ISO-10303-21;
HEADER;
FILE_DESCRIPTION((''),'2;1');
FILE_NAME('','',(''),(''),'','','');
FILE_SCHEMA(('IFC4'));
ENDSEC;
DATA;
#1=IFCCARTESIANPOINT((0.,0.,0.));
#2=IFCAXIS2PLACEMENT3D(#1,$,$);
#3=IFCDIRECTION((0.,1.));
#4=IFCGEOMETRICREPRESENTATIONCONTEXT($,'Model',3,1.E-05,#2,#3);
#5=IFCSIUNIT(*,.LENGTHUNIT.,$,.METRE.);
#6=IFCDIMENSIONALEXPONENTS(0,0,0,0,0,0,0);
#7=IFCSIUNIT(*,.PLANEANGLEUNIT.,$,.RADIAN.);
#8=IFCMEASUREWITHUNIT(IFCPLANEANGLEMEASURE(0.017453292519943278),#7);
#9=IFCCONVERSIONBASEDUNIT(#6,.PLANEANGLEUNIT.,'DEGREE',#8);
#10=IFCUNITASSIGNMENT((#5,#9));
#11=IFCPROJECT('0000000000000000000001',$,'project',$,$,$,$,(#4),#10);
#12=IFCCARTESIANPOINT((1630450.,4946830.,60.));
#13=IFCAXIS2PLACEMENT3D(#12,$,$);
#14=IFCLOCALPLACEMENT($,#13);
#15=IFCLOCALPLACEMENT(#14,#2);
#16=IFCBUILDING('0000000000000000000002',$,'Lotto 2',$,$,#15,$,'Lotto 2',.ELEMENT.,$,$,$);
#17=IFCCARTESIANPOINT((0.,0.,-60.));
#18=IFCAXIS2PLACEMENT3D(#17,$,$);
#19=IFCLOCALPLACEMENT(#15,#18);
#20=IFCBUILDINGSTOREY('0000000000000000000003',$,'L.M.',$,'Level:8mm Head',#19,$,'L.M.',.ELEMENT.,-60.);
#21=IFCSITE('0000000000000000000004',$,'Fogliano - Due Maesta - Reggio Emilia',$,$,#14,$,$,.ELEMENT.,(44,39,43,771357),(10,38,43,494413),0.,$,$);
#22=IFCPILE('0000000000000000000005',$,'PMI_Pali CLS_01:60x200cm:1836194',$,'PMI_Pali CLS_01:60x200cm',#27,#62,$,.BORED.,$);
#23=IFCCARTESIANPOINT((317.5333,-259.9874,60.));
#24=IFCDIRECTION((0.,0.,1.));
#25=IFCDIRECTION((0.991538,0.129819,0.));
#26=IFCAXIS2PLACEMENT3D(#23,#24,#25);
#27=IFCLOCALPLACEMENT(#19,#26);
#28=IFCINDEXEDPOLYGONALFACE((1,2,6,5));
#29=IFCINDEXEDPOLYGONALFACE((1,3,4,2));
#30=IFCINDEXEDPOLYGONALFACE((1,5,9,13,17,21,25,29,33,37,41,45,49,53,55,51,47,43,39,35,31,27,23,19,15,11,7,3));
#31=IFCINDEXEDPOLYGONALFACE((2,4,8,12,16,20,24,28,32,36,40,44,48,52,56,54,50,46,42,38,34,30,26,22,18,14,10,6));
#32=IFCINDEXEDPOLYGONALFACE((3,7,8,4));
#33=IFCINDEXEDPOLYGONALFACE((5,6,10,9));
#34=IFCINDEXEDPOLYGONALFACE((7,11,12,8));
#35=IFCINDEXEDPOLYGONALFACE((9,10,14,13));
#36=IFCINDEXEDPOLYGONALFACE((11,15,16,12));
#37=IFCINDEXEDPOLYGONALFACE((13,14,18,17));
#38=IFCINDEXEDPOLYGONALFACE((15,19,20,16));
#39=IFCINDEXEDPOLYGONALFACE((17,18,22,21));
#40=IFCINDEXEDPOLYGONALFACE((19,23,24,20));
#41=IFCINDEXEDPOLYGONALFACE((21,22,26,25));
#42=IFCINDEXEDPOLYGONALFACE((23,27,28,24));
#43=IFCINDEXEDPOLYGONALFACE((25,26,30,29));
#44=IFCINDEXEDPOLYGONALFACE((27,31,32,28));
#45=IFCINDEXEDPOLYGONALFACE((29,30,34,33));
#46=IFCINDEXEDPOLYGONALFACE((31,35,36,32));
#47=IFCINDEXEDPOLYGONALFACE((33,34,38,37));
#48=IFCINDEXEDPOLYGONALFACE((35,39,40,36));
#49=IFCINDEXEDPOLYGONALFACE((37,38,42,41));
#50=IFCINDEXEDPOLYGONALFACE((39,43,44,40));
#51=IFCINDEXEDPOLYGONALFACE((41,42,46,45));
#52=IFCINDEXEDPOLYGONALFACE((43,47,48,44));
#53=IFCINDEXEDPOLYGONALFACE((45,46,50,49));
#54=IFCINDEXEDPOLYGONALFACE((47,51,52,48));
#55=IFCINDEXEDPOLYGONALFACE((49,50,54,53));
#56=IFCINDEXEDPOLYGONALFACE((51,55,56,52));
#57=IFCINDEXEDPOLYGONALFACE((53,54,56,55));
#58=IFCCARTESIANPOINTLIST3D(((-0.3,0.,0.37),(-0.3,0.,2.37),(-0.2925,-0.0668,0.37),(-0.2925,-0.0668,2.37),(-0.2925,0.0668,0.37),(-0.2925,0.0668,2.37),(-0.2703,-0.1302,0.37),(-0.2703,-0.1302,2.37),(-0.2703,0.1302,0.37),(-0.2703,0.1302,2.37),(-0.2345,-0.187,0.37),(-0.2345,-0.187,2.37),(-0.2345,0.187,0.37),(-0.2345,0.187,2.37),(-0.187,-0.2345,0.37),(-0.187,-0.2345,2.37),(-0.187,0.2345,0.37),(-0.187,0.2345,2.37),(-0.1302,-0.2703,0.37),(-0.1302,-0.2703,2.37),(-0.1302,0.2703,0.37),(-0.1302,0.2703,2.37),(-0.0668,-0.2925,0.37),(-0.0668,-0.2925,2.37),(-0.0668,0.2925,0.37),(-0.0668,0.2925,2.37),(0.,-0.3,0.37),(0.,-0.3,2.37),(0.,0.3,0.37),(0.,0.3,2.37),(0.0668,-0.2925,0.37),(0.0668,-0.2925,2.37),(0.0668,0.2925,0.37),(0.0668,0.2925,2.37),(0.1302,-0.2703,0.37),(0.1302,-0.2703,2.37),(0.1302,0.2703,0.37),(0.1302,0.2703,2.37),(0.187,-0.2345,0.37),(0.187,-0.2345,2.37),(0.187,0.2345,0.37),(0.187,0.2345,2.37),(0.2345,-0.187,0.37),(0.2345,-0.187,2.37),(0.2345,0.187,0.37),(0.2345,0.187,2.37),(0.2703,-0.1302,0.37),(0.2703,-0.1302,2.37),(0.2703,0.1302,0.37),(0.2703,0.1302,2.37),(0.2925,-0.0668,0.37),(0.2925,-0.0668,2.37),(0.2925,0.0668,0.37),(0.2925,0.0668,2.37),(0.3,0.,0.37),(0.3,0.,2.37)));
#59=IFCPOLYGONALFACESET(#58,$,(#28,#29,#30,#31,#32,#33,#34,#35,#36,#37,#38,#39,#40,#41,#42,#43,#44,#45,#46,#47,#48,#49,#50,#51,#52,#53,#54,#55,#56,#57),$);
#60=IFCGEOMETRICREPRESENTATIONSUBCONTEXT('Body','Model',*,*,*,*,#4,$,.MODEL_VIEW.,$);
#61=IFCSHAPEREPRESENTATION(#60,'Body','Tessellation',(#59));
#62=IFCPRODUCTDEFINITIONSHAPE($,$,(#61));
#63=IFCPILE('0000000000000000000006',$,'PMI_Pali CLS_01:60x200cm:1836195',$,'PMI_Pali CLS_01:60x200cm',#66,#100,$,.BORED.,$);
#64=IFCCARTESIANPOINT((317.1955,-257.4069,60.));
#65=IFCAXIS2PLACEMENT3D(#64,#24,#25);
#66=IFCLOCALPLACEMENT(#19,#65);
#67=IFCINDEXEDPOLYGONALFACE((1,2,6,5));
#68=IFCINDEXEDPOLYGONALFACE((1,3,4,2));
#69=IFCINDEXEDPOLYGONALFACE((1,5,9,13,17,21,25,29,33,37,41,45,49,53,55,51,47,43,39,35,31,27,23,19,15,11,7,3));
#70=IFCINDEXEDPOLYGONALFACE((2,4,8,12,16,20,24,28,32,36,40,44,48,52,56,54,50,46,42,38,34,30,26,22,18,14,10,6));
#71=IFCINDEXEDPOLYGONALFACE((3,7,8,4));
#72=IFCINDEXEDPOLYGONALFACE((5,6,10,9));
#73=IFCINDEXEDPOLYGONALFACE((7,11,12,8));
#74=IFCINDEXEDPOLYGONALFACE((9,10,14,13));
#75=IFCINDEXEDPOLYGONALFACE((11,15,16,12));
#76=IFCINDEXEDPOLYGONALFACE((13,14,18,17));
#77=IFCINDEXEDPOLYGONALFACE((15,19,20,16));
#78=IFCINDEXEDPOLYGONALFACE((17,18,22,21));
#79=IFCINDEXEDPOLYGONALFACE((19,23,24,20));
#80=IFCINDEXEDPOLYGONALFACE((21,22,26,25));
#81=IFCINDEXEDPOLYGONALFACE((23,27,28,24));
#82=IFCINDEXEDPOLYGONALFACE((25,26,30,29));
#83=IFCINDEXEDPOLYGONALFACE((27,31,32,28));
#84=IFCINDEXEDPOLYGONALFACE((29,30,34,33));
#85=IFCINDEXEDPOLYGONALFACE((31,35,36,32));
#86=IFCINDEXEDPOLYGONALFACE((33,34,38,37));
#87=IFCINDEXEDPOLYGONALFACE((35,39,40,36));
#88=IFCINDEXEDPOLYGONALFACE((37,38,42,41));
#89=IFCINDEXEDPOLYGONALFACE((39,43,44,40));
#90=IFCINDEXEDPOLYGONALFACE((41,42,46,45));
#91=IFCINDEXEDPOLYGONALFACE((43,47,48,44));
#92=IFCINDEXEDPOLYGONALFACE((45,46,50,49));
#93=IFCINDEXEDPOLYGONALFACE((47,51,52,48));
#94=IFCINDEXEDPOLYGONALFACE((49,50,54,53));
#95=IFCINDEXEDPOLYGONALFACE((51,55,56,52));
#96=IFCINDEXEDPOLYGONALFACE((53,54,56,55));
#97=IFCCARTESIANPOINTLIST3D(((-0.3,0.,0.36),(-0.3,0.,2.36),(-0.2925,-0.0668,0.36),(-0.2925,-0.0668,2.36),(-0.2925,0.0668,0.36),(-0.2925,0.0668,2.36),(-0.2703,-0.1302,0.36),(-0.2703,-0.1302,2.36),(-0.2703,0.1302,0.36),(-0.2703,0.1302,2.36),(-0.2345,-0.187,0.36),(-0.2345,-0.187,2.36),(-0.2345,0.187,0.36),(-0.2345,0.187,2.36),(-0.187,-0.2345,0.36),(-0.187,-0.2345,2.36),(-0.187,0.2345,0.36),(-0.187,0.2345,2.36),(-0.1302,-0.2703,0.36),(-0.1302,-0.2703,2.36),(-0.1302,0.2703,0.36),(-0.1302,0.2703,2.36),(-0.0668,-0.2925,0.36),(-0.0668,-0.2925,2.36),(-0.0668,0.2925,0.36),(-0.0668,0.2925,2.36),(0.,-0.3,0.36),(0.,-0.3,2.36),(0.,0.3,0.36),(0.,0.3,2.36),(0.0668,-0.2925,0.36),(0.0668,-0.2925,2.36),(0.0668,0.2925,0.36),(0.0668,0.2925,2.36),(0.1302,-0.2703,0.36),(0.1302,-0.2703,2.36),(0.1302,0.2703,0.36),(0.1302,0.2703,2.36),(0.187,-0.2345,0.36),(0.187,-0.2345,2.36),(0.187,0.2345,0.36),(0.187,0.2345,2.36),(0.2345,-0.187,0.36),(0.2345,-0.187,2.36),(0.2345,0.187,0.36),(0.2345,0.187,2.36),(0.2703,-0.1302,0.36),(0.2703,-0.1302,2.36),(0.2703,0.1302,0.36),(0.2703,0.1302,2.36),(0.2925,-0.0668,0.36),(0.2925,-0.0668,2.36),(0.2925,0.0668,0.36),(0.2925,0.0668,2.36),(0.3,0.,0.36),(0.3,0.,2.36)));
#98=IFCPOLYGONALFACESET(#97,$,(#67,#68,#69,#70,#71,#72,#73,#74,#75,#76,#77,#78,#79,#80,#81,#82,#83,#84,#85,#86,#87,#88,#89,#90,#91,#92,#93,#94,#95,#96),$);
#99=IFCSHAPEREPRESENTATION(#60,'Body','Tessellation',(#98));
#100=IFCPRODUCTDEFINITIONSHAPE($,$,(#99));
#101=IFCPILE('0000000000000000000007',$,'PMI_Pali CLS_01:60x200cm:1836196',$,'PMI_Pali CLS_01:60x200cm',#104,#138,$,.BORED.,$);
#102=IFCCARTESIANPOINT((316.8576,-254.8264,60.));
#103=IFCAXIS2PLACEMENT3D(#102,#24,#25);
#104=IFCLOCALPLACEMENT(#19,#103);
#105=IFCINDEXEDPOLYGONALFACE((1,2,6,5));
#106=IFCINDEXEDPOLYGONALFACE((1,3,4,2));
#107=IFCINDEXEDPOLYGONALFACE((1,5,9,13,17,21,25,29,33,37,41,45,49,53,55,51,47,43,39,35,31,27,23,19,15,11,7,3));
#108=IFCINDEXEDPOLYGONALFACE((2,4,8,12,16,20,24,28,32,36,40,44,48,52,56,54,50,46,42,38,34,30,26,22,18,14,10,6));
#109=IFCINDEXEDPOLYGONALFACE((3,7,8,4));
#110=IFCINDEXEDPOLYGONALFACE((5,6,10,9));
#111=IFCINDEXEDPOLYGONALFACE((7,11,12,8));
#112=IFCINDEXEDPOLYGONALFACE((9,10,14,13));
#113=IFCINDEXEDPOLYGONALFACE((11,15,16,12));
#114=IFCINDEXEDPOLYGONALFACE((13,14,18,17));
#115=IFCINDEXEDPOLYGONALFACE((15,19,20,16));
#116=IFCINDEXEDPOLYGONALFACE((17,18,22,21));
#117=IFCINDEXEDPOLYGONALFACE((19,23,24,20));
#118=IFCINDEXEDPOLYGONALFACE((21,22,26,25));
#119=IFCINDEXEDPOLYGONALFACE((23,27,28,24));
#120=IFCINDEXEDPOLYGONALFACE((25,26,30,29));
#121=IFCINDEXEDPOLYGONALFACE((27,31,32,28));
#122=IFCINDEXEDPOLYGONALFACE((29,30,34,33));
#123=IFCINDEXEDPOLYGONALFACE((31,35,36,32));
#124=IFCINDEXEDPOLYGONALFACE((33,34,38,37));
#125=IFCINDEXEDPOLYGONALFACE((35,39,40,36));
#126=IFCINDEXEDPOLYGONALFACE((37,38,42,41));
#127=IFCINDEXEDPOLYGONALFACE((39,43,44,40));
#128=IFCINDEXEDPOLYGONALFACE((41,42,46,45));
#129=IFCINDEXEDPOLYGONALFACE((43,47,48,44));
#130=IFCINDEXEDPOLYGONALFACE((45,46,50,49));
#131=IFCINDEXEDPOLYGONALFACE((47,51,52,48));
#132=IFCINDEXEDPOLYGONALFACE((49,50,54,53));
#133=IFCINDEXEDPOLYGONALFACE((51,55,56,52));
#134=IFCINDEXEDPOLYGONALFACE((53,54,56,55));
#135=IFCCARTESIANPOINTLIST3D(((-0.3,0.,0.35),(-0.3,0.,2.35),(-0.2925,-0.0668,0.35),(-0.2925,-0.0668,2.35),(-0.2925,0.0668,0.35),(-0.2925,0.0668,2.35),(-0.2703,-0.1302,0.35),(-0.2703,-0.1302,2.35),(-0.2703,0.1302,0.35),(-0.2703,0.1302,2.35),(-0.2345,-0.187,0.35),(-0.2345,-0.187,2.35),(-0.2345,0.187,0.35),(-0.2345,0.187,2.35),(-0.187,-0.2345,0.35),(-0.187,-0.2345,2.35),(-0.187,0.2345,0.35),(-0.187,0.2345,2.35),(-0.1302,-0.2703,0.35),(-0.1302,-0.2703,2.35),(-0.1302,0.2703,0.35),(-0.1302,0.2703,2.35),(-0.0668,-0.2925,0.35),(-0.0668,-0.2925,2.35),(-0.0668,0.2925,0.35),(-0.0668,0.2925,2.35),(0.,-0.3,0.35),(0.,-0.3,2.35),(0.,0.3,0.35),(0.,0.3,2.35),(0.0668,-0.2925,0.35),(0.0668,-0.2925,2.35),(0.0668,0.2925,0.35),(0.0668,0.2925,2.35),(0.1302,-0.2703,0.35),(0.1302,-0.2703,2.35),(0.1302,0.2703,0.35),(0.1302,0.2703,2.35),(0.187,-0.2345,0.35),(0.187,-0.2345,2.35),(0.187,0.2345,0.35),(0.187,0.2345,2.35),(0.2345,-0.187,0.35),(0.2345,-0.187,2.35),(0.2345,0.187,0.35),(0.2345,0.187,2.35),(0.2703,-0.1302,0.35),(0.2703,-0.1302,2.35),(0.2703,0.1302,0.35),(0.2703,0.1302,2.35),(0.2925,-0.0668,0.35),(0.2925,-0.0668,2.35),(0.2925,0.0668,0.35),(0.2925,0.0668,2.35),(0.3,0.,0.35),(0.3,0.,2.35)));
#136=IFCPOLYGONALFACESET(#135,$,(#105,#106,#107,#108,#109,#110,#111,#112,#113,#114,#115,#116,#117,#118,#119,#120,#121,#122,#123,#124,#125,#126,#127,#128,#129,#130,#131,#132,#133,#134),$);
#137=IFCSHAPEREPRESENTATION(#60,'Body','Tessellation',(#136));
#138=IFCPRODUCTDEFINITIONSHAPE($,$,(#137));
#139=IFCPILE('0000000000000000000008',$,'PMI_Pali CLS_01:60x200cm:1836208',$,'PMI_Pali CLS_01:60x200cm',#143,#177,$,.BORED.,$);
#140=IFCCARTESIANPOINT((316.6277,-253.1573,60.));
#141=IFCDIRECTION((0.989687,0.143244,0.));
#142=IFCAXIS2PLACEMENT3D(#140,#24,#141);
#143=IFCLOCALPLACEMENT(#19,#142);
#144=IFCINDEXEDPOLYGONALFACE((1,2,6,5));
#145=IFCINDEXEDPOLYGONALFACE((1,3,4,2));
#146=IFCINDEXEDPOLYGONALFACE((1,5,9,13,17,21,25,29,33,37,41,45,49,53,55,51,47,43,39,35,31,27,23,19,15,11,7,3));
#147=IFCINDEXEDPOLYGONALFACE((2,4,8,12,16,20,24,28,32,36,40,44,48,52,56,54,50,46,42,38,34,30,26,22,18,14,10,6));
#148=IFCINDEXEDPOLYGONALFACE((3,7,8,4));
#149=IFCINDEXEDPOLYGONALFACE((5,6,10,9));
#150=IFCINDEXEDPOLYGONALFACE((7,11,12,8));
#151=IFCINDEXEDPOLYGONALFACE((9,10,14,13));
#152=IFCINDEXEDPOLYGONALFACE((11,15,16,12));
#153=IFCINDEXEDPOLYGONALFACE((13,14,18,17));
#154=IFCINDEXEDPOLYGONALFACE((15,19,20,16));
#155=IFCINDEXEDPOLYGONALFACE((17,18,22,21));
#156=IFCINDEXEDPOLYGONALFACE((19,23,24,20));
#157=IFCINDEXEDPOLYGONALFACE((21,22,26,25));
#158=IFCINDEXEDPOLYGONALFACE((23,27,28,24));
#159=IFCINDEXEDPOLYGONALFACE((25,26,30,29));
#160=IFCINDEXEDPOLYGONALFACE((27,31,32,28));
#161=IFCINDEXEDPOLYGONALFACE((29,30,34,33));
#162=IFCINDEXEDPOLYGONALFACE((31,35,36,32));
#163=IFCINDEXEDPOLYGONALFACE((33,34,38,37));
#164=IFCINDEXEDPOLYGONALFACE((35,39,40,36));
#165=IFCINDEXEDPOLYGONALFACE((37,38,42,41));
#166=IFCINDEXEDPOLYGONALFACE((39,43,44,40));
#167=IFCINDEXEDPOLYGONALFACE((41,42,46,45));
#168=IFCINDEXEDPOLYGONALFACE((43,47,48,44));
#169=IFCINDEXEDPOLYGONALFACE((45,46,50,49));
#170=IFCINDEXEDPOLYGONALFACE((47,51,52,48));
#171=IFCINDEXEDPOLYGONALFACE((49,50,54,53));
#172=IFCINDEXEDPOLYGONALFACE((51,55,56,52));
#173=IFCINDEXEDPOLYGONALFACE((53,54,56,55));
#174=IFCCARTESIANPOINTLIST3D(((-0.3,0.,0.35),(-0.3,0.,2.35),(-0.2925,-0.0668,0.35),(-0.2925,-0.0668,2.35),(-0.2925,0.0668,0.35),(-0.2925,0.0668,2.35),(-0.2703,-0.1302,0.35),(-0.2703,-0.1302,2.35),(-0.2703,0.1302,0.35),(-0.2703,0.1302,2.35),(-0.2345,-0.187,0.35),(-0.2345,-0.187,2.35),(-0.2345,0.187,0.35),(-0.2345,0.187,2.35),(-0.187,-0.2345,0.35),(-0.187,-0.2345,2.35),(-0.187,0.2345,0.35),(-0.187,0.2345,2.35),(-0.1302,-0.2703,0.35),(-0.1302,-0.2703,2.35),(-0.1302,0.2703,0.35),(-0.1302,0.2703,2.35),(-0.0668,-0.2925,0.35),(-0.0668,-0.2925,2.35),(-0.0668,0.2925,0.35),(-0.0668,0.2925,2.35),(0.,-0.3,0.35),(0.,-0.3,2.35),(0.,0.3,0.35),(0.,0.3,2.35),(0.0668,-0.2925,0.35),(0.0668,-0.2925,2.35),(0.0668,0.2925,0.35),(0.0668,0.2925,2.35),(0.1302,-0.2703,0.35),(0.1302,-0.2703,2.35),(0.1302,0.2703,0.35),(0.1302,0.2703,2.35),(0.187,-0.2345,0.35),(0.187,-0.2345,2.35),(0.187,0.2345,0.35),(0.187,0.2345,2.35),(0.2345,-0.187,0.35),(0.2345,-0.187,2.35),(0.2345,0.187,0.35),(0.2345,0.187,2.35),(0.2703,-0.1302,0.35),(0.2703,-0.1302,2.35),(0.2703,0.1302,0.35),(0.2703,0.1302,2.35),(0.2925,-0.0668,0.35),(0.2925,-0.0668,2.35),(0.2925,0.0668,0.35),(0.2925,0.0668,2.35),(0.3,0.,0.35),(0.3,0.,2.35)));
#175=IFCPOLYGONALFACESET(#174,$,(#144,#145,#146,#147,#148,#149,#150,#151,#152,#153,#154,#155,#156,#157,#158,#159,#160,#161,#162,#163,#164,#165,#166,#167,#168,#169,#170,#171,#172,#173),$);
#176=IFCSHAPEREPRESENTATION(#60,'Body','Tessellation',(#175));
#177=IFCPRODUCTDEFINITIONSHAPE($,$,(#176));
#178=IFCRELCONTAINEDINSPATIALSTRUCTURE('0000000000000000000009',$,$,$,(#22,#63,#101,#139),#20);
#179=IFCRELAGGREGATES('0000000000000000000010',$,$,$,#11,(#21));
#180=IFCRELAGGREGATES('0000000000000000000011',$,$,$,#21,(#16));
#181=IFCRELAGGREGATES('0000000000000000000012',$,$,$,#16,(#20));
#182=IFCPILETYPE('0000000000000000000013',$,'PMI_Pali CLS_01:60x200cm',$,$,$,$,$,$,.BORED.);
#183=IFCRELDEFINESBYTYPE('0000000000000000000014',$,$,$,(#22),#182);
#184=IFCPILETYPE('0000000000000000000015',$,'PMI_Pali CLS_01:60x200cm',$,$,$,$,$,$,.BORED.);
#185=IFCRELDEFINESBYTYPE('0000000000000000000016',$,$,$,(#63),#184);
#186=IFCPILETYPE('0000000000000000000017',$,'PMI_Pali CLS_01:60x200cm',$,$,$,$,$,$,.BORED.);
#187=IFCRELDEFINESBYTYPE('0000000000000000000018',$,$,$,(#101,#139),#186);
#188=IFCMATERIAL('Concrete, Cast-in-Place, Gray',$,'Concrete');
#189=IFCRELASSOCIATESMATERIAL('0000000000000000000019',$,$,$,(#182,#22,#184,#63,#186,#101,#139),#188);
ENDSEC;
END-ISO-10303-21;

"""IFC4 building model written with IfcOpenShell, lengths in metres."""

from ifc_helpers import new_model, entity, si_unit, converted_unit, direction, frame, origin, place, context, subcontext, project, spatial, arc, indexed_curve, outline, extrude, source, transform, mapped, material, type_object, type_shapes, element, save


model = new_model("IFC4")

# Units and contexts
model_context = context("Model", 3, precision=1e-05, world=origin(), true_north=direction((0.0, 1.0)))
body_context = subcontext(model_context, "Body", "Model", "MODEL_VIEW")
ifc_project = project(units=[si_unit("LENGTHUNIT", "METRE"), converted_unit("PLANEANGLEUNIT", "DEGREE", entity("IfcPlaneAngleMeasure", 0.017453292519943278), si_unit("PLANEANGLEUNIT", "RADIAN"), dimensions=[0, 0, 0, 0, 0, 0, 0])], contexts=[model_context])

# Site, building, storey
site_placement = place(None, frame((1630450.0, 4946830.0, 60.0)))
site = spatial("IfcSite", under=ifc_project, at=site_placement, Name="Fogliano - Due Maesta - Reggio Emilia", CompositionType="ELEMENT", RefLatitude=(44, 39, 43, 771357), RefLongitude=(10, 38, 43, 494413), RefElevation=0.0)
building_placement = place(site_placement, origin())
building = spatial("IfcBuilding", under=site, at=building_placement, Name="Lotto 2", LongName="Lotto 2", CompositionType="ELEMENT")
storey_placement = place(building_placement, frame((0.0, 0.0, -60.0)))
storey = spatial("IfcBuildingStorey", under=building, at=storey_placement, Name="L.M.", ObjectType="Level:8mm Head", LongName="L.M.", CompositionType="ELEMENT", Elevation=-60.0)

# Piles
ifc_material_1 = material(Name="Concrete, Cast-in-Place, Gray", Category="Concrete")
pile_type_1 = type_object("IfcPileType", Name="PMI_Pali CLS_01:60x200cm", PredefinedType="BORED", material=ifc_material_1)
shared_shape_1 = source(origin(), body_context, "Body", "SweptSolid", [
    extrude(outline(indexed_curve([(-0.3, 0.0), (0.0, -0.3), (0.3, 0.0), (0.0, 0.3)], segments=[arc(1, 2, 3), arc(3, 4, 1)], self_intersect=False)), frame((0.0, 0.0, 0.37)), (0.0, 0.0, 1.0), 2.0),
])
type_shapes(pile_type_1, [shared_shape_1])
for number, where, z_axis, x_axis, name in (
    (1, (317.5333, -259.9874, 60.0), (0.0, 0.0, 1.0), (0.991538, 0.129819, 0.0), "PMI_Pali CLS_01:60x200cm:1836194"),
):
    element("IfcPile", number, at=place(storey_placement, frame(where, z_axis=z_axis, x_axis=x_axis)), inside=storey, type_object=pile_type_1, material=ifc_material_1, Name=name, ObjectType="PMI_Pali CLS_01:60x200cm", PredefinedType="BORED", context=body_context, shape_type="MappedRepresentation", body=[
        mapped(shared_shape_1, transform((0.0, 0.0, 0.0), scale=1.0)),
    ])
pile_type_2 = type_object("IfcPileType", Name="PMI_Pali CLS_01:60x200cm", PredefinedType="BORED", material=ifc_material_1)
shared_shape_2 = source(origin(), body_context, "Body", "SweptSolid", [
    extrude(outline(indexed_curve([(-0.3, 0.0), (0.0, -0.3), (0.3, 0.0), (0.0, 0.3)], segments=[arc(1, 2, 3), arc(3, 4, 1)], self_intersect=False)), frame((0.0, 0.0, 0.36)), (0.0, 0.0, 1.0), 2.0),
])
type_shapes(pile_type_2, [shared_shape_2])
pile_1_placement = place(storey_placement, frame((317.1955, -257.4069, 60.0), z_axis=(0.0, 0.0, 1.0), x_axis=(0.991538, 0.129819, 0.0)))
element("IfcPile", 2, at=pile_1_placement, inside=storey, type_object=pile_type_2, material=ifc_material_1, Name="PMI_Pali CLS_01:60x200cm:1836195", ObjectType="PMI_Pali CLS_01:60x200cm", PredefinedType="BORED", context=body_context, shape_type="MappedRepresentation", body=[
    mapped(shared_shape_2, transform((0.0, 0.0, 0.0), scale=1.0)),
])
pile_type_3 = type_object("IfcPileType", Name="PMI_Pali CLS_01:60x200cm", PredefinedType="BORED", material=ifc_material_1)
shared_shape_3 = source(origin(), body_context, "Body", "SweptSolid", [
    extrude(outline(indexed_curve([(-0.3, 0.0), (0.0, -0.3), (0.3, 0.0), (0.0, 0.3)], segments=[arc(1, 2, 3), arc(3, 4, 1)], self_intersect=False)), frame((0.0, 0.0, 0.35)), (0.0, 0.0, 1.0), 2.0),
])
type_shapes(pile_type_3, [shared_shape_3])
for number, where, z_axis, x_axis, name in (
    (3, (316.8576, -254.8264, 60.0), (0.0, 0.0, 1.0), (0.991538, 0.129819, 0.0), "PMI_Pali CLS_01:60x200cm:1836196"),
    (4, (316.6277, -253.1573, 60.0), (0.0, 0.0, 1.0), (0.989687, 0.143244, 0.0), "PMI_Pali CLS_01:60x200cm:1836208"),
):
    element("IfcPile", number, at=place(storey_placement, frame(where, z_axis=z_axis, x_axis=x_axis)), inside=storey, type_object=pile_type_3, material=ifc_material_1, Name=name, ObjectType="PMI_Pali CLS_01:60x200cm", PredefinedType="BORED", context=body_context, shape_type="MappedRepresentation", body=[
        mapped(shared_shape_3, transform((0.0, 0.0, 0.0), scale=1.0)),
    ])

save(model, "model.ifc")
